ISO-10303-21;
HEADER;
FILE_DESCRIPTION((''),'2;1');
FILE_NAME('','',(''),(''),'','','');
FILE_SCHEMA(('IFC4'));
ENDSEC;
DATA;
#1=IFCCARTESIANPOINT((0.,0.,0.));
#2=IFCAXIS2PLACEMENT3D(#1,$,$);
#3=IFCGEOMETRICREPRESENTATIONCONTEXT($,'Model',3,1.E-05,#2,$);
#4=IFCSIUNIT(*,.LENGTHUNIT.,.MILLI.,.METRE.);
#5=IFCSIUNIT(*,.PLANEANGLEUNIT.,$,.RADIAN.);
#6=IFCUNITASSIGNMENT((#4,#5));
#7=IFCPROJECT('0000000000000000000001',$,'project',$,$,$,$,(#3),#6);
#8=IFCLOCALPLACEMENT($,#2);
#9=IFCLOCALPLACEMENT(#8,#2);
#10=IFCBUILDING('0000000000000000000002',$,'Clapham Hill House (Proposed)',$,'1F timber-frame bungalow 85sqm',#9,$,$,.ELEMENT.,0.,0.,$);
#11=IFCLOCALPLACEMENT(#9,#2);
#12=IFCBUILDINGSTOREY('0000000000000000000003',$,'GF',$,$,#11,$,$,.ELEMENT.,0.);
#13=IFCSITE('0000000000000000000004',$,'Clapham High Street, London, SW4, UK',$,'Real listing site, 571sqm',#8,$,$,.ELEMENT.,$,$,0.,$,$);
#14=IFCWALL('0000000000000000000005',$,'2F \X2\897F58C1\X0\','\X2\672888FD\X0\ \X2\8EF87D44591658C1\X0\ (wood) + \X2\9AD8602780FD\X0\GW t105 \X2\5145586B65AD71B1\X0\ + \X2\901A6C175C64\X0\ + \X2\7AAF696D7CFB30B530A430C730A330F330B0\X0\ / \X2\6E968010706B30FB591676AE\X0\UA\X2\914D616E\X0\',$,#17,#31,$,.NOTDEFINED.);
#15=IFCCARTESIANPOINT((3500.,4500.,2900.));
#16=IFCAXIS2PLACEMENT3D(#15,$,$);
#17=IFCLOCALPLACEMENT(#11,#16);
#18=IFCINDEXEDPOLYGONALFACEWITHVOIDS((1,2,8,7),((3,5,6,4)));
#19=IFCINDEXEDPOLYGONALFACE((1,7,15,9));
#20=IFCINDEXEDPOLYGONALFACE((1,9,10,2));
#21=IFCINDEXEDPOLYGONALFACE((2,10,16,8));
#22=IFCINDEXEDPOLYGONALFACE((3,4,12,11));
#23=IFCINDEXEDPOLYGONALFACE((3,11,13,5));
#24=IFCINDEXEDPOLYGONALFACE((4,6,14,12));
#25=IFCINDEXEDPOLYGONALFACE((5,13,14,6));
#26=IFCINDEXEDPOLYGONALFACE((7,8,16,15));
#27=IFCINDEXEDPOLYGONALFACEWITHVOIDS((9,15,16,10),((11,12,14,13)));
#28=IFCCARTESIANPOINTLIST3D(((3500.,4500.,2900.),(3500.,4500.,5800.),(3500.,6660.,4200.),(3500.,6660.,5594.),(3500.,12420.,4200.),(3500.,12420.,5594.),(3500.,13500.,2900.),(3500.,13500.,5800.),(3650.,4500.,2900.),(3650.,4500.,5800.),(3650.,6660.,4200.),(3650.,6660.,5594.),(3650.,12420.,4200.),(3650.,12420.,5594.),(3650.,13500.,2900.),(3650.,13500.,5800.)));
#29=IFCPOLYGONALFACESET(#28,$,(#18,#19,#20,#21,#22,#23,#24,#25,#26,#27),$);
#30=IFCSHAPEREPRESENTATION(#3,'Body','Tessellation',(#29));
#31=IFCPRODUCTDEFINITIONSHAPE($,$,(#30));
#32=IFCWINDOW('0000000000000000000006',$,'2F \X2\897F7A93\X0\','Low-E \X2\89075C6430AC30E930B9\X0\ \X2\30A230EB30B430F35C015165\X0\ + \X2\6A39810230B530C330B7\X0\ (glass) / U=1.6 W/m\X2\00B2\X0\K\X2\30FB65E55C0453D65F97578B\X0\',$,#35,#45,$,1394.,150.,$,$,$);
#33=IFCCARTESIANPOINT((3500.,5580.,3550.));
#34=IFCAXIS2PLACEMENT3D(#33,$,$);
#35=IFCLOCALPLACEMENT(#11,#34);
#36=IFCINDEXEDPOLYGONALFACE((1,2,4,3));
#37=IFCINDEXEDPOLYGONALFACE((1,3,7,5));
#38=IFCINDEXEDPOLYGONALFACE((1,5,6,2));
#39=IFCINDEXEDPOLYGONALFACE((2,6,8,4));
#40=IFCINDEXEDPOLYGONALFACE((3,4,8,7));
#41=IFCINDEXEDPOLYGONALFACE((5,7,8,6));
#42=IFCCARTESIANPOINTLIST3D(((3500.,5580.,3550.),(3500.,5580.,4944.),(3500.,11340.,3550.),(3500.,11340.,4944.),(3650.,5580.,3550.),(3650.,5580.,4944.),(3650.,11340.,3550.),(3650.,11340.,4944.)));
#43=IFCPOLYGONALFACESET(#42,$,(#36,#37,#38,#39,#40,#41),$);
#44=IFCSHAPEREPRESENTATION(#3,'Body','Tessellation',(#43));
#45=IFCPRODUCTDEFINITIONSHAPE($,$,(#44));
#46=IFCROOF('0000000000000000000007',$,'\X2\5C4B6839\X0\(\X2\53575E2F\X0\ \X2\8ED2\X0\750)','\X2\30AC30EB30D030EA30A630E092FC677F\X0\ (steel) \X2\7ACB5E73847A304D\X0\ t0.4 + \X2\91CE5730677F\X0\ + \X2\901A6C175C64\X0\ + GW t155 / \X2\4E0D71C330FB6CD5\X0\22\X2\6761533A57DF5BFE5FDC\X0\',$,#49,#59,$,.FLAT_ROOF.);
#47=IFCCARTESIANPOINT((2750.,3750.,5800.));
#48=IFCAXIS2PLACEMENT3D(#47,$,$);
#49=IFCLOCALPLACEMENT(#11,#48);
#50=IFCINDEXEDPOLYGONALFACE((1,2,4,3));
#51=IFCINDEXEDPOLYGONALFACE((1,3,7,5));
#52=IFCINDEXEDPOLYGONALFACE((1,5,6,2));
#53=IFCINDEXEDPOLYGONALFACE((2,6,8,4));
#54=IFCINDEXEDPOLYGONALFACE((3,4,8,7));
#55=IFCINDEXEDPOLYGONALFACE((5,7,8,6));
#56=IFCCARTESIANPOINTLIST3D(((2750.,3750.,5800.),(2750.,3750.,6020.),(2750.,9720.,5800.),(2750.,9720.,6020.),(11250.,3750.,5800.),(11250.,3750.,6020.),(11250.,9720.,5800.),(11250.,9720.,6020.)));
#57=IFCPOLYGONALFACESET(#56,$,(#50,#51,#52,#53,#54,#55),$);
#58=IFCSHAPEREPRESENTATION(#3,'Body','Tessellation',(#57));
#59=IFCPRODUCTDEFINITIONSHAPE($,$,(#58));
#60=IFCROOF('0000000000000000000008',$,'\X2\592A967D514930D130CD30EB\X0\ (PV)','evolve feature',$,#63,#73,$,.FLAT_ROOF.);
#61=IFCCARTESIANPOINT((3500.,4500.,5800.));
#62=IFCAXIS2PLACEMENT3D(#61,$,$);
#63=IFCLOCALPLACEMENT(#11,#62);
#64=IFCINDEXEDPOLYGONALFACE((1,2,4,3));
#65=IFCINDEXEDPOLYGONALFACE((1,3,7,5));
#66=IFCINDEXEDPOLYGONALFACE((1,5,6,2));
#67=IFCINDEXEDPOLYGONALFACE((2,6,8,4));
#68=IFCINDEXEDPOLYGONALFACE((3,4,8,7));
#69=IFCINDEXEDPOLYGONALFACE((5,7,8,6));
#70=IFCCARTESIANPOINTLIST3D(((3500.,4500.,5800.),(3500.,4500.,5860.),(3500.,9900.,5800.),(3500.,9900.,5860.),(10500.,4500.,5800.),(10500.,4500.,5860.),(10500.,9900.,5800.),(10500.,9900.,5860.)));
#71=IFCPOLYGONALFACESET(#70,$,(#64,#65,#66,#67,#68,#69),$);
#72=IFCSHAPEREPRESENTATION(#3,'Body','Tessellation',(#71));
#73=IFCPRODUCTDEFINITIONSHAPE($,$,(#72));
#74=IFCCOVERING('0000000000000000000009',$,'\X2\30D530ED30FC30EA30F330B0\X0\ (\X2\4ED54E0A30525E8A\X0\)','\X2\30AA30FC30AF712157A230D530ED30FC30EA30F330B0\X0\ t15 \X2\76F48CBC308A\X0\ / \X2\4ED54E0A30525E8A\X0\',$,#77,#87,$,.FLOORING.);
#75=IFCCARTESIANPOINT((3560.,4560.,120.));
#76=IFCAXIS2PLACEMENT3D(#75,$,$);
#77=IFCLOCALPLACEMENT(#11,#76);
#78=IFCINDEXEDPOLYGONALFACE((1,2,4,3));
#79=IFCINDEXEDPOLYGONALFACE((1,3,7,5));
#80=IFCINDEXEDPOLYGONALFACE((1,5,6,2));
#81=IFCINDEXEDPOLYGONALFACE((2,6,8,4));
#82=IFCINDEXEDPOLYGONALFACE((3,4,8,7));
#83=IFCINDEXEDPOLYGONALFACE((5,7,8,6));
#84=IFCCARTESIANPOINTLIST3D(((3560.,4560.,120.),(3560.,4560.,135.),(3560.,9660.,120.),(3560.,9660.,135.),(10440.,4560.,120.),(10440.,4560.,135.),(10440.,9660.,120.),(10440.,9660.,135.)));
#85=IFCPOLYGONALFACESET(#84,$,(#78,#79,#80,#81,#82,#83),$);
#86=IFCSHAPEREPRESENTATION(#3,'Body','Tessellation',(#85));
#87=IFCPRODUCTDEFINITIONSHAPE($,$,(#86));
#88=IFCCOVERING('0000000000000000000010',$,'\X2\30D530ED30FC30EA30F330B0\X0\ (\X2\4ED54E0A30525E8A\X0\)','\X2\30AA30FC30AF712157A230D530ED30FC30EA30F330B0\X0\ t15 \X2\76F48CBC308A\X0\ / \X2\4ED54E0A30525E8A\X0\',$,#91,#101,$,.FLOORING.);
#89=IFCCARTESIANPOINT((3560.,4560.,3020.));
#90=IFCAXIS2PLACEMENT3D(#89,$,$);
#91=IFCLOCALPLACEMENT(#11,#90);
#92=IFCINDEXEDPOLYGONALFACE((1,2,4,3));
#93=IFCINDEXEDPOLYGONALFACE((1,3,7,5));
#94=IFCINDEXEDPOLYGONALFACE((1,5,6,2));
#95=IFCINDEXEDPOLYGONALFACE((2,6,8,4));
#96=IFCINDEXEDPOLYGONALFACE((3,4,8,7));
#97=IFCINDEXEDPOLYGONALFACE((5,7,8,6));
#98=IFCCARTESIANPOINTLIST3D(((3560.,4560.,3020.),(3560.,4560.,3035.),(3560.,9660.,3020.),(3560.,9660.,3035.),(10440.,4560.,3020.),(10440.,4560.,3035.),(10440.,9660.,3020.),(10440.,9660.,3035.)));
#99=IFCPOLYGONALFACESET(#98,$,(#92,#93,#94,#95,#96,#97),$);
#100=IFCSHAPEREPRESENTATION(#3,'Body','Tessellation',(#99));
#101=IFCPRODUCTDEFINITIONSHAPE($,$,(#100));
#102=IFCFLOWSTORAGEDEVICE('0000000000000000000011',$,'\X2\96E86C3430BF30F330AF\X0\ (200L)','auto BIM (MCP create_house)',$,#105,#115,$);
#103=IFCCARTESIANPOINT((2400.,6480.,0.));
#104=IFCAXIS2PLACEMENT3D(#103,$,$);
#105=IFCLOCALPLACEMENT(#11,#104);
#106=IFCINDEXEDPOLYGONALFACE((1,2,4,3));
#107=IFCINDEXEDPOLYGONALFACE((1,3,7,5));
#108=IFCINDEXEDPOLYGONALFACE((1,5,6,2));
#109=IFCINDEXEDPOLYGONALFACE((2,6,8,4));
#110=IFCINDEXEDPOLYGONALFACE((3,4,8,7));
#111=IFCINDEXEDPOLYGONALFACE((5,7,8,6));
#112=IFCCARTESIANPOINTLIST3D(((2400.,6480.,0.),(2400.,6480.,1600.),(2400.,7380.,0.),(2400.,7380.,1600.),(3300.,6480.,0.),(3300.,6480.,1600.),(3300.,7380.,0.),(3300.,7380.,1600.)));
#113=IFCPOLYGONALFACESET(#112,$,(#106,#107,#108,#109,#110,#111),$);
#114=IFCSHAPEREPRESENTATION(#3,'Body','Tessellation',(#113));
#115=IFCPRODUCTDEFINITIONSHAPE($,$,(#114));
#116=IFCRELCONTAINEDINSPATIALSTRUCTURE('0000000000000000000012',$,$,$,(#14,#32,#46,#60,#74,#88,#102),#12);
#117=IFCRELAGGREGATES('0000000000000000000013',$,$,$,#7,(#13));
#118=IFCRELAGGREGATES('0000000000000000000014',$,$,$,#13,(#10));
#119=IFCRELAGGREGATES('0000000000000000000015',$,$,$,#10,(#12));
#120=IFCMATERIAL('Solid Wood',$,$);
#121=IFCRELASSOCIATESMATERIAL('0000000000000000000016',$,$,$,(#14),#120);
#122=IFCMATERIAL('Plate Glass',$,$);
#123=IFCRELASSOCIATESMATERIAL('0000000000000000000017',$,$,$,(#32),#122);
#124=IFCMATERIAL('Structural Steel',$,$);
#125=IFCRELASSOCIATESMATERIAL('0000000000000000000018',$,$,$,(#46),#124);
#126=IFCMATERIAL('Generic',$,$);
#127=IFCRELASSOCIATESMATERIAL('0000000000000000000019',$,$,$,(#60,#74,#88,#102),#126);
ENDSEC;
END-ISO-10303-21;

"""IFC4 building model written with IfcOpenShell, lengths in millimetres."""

from ifc_helpers import new_model, si_unit, frame, frame_2d, origin, place, context, project, spatial, rectangle, extrude, material, element, fill, save


model = new_model("IFC4")

# Units and contexts
model_context = context("Model", 3, precision=1e-05, world=origin())
ifc_project = project(units=[si_unit("LENGTHUNIT", "METRE", prefix="MILLI"), si_unit("PLANEANGLEUNIT", "RADIAN")], contexts=[model_context])

# Site, building, storey
site_placement = place(None, origin())
site = spatial("IfcSite", under=ifc_project, at=site_placement, Name="Clapham High Street, London, SW4, UK", ObjectType="Real listing site, 571sqm", CompositionType="ELEMENT", RefElevation=0.0)
building_placement = place(site_placement, origin())
building = spatial("IfcBuilding", under=site, at=building_placement, Name="Clapham Hill House (Proposed)", ObjectType="1F timber-frame bungalow 85sqm", CompositionType="ELEMENT", ElevationOfRefHeight=0.0, ElevationOfTerrain=0.0)
storey_placement = place(building_placement, origin())
storey = spatial("IfcBuildingStorey", under=building, at=storey_placement, Name="GF", CompositionType="ELEMENT", Elevation=0.0)

# Shared definitions
ifc_material_1 = material(Name="Solid Wood")
ifc_material_2 = material(Name="Generic")

# Shared definitions
ifc_material_3 = material(Name="Plate Glass")

# Wall, opening, window
wall_1_placement = place(storey_placement, frame((3500.0, 4500.0, 2900.0)))
wall_1 = element("IfcWall", 1, at=wall_1_placement, inside=storey, material=ifc_material_1, Name="2F 西壁", Description="木製 軸組外壁 (wood) + 高性能GW t105 充填断熱 + 通気層 + 窯業系サイディング / 準耐火・外皮UA配慮", PredefinedType="NOTDEFINED", context=model_context, shape_type="SweptSolid", body=[
    extrude(rectangle(XDim=150.0, YDim=9000.0, at=frame_2d((75.0, 4500.0))), frame((3500.0, 4500.0, 2900.0)), (0.0, 0.0, 1.0), 2900.0),
])
opening_1_placement = place(storey_placement, frame((3500.0, 5580.0, 3550.0)))
opening_1 = element("IfcOpeningElement", 2, at=opening_1_placement, cuts=wall_1, PredefinedType="NOTDEFINED", context=model_context, shape_type="SweptSolid", body=[
    extrude(rectangle(XDim=150.0, YDim=5760.0, at=frame_2d((75.0, 2880.0))), frame((3500.0, 5580.0, 3550.0)), (0.0, 0.0, 1.0), 1394.0),
])
window_1_placement = place(storey_placement, frame((3500.0, 5580.0, 3550.0)))
window_1 = element("IfcWindow", 3, at=window_1_placement, inside=storey, material=ifc_material_3, Name="2F 西窓", Description="Low-E 複層ガラス アルゴン封入 + 樹脂サッシ (glass) / U=1.6 W/m²K・日射取得型", OverallHeight=1394.0, OverallWidth=150.0, context=model_context, shape_type="SweptSolid", body=[
    extrude(rectangle(XDim=150.0, YDim=5760.0, at=frame_2d((75.0, 2880.0))), frame((3500.0, 5580.0, 3550.0)), (0.0, 0.0, 1.0), 1394.0),
])
fill(opening_1, window_1)

# Roofs
ifc_material_4 = material(Name="Structural Steel")
for number, where, name in (
    (4, (2750.0, 3750.0, 5800.0), "屋根(南帯 軒750)"),
):
    element("IfcRoof", number, at=place(storey_placement, frame(where)), inside=storey, material=ifc_material_4, Name=name, Description="ガルバリウム鋼板 (steel) 立平葺き t0.4 + 野地板 + 通気層 + GW t155 / 不燃・法22条区域対応", PredefinedType="FLAT_ROOF", context=model_context, shape_type="SweptSolid", body=[
        extrude(rectangle(XDim=8500.0, YDim=5970.0, at=frame_2d((4250.0, 2985.0))), frame((2750.0, 3750.0, 5800.0)), (0.0, 0.0, 1.0), 220.0),
    ])
roof_placement = place(storey_placement, frame((3500.0, 4500.0, 5800.0)))
element("IfcRoof", 5, at=roof_placement, inside=storey, material=ifc_material_2, Name="太陽光パネル (PV)", Description="evolve feature", PredefinedType="FLAT_ROOF", context=model_context, shape_type="SweptSolid", body=[
    extrude(rectangle(XDim=7000.0, YDim=5400.0, at=frame_2d((3500.0, 2700.0))), frame((3500.0, 4500.0, 5800.0)), (0.0, 0.0, 1.0), 60.0),
])

# Coverings
covering_1_placement = place(storey_placement, frame((3560.0, 4560.0, 120.0)))
element("IfcCovering", 6, at=covering_1_placement, inside=storey, material=ifc_material_2, Name="フローリング (仕上げ床)", Description="オーク無垢フローリング t15 直貼り / 仕上げ床", PredefinedType="FLOORING", context=model_context, shape_type="SweptSolid", body=[
    extrude(rectangle(XDim=6880.0, YDim=5100.0, at=frame_2d((3440.0, 2550.0))), frame((3560.0, 4560.0, 120.0)), (0.0, 0.0, 1.0), 15.0),
])
covering_2_placement = place(storey_placement, frame((3560.0, 4560.0, 3020.0)))
element("IfcCovering", 7, at=covering_2_placement, inside=storey, material=ifc_material_2, Name="フローリング (仕上げ床)", Description="オーク無垢フローリング t15 直貼り / 仕上げ床", PredefinedType="FLOORING", context=model_context, shape_type="SweptSolid", body=[
    extrude(rectangle(XDim=6880.0, YDim=5100.0, at=frame_2d((3440.0, 2550.0))), frame((3560.0, 4560.0, 3020.0)), (0.0, 0.0, 1.0), 15.0),
])

# Flow storage device
flow_storage_device_placement = place(storey_placement, frame((2400.0, 6480.0, 0.0)))
element("IfcFlowStorageDevice", 8, at=flow_storage_device_placement, inside=storey, material=ifc_material_2, Name="雨水タンク (200L)", Description="auto BIM (MCP create_house)", context=model_context, shape_type="SweptSolid", body=[
    extrude(rectangle(XDim=900.0, YDim=900.0, at=frame_2d((450.0, 450.0))), frame((2400.0, 6480.0, 0.0)), (0.0, 0.0, 1.0), 1600.0),
])

save(model, "model.ifc")
